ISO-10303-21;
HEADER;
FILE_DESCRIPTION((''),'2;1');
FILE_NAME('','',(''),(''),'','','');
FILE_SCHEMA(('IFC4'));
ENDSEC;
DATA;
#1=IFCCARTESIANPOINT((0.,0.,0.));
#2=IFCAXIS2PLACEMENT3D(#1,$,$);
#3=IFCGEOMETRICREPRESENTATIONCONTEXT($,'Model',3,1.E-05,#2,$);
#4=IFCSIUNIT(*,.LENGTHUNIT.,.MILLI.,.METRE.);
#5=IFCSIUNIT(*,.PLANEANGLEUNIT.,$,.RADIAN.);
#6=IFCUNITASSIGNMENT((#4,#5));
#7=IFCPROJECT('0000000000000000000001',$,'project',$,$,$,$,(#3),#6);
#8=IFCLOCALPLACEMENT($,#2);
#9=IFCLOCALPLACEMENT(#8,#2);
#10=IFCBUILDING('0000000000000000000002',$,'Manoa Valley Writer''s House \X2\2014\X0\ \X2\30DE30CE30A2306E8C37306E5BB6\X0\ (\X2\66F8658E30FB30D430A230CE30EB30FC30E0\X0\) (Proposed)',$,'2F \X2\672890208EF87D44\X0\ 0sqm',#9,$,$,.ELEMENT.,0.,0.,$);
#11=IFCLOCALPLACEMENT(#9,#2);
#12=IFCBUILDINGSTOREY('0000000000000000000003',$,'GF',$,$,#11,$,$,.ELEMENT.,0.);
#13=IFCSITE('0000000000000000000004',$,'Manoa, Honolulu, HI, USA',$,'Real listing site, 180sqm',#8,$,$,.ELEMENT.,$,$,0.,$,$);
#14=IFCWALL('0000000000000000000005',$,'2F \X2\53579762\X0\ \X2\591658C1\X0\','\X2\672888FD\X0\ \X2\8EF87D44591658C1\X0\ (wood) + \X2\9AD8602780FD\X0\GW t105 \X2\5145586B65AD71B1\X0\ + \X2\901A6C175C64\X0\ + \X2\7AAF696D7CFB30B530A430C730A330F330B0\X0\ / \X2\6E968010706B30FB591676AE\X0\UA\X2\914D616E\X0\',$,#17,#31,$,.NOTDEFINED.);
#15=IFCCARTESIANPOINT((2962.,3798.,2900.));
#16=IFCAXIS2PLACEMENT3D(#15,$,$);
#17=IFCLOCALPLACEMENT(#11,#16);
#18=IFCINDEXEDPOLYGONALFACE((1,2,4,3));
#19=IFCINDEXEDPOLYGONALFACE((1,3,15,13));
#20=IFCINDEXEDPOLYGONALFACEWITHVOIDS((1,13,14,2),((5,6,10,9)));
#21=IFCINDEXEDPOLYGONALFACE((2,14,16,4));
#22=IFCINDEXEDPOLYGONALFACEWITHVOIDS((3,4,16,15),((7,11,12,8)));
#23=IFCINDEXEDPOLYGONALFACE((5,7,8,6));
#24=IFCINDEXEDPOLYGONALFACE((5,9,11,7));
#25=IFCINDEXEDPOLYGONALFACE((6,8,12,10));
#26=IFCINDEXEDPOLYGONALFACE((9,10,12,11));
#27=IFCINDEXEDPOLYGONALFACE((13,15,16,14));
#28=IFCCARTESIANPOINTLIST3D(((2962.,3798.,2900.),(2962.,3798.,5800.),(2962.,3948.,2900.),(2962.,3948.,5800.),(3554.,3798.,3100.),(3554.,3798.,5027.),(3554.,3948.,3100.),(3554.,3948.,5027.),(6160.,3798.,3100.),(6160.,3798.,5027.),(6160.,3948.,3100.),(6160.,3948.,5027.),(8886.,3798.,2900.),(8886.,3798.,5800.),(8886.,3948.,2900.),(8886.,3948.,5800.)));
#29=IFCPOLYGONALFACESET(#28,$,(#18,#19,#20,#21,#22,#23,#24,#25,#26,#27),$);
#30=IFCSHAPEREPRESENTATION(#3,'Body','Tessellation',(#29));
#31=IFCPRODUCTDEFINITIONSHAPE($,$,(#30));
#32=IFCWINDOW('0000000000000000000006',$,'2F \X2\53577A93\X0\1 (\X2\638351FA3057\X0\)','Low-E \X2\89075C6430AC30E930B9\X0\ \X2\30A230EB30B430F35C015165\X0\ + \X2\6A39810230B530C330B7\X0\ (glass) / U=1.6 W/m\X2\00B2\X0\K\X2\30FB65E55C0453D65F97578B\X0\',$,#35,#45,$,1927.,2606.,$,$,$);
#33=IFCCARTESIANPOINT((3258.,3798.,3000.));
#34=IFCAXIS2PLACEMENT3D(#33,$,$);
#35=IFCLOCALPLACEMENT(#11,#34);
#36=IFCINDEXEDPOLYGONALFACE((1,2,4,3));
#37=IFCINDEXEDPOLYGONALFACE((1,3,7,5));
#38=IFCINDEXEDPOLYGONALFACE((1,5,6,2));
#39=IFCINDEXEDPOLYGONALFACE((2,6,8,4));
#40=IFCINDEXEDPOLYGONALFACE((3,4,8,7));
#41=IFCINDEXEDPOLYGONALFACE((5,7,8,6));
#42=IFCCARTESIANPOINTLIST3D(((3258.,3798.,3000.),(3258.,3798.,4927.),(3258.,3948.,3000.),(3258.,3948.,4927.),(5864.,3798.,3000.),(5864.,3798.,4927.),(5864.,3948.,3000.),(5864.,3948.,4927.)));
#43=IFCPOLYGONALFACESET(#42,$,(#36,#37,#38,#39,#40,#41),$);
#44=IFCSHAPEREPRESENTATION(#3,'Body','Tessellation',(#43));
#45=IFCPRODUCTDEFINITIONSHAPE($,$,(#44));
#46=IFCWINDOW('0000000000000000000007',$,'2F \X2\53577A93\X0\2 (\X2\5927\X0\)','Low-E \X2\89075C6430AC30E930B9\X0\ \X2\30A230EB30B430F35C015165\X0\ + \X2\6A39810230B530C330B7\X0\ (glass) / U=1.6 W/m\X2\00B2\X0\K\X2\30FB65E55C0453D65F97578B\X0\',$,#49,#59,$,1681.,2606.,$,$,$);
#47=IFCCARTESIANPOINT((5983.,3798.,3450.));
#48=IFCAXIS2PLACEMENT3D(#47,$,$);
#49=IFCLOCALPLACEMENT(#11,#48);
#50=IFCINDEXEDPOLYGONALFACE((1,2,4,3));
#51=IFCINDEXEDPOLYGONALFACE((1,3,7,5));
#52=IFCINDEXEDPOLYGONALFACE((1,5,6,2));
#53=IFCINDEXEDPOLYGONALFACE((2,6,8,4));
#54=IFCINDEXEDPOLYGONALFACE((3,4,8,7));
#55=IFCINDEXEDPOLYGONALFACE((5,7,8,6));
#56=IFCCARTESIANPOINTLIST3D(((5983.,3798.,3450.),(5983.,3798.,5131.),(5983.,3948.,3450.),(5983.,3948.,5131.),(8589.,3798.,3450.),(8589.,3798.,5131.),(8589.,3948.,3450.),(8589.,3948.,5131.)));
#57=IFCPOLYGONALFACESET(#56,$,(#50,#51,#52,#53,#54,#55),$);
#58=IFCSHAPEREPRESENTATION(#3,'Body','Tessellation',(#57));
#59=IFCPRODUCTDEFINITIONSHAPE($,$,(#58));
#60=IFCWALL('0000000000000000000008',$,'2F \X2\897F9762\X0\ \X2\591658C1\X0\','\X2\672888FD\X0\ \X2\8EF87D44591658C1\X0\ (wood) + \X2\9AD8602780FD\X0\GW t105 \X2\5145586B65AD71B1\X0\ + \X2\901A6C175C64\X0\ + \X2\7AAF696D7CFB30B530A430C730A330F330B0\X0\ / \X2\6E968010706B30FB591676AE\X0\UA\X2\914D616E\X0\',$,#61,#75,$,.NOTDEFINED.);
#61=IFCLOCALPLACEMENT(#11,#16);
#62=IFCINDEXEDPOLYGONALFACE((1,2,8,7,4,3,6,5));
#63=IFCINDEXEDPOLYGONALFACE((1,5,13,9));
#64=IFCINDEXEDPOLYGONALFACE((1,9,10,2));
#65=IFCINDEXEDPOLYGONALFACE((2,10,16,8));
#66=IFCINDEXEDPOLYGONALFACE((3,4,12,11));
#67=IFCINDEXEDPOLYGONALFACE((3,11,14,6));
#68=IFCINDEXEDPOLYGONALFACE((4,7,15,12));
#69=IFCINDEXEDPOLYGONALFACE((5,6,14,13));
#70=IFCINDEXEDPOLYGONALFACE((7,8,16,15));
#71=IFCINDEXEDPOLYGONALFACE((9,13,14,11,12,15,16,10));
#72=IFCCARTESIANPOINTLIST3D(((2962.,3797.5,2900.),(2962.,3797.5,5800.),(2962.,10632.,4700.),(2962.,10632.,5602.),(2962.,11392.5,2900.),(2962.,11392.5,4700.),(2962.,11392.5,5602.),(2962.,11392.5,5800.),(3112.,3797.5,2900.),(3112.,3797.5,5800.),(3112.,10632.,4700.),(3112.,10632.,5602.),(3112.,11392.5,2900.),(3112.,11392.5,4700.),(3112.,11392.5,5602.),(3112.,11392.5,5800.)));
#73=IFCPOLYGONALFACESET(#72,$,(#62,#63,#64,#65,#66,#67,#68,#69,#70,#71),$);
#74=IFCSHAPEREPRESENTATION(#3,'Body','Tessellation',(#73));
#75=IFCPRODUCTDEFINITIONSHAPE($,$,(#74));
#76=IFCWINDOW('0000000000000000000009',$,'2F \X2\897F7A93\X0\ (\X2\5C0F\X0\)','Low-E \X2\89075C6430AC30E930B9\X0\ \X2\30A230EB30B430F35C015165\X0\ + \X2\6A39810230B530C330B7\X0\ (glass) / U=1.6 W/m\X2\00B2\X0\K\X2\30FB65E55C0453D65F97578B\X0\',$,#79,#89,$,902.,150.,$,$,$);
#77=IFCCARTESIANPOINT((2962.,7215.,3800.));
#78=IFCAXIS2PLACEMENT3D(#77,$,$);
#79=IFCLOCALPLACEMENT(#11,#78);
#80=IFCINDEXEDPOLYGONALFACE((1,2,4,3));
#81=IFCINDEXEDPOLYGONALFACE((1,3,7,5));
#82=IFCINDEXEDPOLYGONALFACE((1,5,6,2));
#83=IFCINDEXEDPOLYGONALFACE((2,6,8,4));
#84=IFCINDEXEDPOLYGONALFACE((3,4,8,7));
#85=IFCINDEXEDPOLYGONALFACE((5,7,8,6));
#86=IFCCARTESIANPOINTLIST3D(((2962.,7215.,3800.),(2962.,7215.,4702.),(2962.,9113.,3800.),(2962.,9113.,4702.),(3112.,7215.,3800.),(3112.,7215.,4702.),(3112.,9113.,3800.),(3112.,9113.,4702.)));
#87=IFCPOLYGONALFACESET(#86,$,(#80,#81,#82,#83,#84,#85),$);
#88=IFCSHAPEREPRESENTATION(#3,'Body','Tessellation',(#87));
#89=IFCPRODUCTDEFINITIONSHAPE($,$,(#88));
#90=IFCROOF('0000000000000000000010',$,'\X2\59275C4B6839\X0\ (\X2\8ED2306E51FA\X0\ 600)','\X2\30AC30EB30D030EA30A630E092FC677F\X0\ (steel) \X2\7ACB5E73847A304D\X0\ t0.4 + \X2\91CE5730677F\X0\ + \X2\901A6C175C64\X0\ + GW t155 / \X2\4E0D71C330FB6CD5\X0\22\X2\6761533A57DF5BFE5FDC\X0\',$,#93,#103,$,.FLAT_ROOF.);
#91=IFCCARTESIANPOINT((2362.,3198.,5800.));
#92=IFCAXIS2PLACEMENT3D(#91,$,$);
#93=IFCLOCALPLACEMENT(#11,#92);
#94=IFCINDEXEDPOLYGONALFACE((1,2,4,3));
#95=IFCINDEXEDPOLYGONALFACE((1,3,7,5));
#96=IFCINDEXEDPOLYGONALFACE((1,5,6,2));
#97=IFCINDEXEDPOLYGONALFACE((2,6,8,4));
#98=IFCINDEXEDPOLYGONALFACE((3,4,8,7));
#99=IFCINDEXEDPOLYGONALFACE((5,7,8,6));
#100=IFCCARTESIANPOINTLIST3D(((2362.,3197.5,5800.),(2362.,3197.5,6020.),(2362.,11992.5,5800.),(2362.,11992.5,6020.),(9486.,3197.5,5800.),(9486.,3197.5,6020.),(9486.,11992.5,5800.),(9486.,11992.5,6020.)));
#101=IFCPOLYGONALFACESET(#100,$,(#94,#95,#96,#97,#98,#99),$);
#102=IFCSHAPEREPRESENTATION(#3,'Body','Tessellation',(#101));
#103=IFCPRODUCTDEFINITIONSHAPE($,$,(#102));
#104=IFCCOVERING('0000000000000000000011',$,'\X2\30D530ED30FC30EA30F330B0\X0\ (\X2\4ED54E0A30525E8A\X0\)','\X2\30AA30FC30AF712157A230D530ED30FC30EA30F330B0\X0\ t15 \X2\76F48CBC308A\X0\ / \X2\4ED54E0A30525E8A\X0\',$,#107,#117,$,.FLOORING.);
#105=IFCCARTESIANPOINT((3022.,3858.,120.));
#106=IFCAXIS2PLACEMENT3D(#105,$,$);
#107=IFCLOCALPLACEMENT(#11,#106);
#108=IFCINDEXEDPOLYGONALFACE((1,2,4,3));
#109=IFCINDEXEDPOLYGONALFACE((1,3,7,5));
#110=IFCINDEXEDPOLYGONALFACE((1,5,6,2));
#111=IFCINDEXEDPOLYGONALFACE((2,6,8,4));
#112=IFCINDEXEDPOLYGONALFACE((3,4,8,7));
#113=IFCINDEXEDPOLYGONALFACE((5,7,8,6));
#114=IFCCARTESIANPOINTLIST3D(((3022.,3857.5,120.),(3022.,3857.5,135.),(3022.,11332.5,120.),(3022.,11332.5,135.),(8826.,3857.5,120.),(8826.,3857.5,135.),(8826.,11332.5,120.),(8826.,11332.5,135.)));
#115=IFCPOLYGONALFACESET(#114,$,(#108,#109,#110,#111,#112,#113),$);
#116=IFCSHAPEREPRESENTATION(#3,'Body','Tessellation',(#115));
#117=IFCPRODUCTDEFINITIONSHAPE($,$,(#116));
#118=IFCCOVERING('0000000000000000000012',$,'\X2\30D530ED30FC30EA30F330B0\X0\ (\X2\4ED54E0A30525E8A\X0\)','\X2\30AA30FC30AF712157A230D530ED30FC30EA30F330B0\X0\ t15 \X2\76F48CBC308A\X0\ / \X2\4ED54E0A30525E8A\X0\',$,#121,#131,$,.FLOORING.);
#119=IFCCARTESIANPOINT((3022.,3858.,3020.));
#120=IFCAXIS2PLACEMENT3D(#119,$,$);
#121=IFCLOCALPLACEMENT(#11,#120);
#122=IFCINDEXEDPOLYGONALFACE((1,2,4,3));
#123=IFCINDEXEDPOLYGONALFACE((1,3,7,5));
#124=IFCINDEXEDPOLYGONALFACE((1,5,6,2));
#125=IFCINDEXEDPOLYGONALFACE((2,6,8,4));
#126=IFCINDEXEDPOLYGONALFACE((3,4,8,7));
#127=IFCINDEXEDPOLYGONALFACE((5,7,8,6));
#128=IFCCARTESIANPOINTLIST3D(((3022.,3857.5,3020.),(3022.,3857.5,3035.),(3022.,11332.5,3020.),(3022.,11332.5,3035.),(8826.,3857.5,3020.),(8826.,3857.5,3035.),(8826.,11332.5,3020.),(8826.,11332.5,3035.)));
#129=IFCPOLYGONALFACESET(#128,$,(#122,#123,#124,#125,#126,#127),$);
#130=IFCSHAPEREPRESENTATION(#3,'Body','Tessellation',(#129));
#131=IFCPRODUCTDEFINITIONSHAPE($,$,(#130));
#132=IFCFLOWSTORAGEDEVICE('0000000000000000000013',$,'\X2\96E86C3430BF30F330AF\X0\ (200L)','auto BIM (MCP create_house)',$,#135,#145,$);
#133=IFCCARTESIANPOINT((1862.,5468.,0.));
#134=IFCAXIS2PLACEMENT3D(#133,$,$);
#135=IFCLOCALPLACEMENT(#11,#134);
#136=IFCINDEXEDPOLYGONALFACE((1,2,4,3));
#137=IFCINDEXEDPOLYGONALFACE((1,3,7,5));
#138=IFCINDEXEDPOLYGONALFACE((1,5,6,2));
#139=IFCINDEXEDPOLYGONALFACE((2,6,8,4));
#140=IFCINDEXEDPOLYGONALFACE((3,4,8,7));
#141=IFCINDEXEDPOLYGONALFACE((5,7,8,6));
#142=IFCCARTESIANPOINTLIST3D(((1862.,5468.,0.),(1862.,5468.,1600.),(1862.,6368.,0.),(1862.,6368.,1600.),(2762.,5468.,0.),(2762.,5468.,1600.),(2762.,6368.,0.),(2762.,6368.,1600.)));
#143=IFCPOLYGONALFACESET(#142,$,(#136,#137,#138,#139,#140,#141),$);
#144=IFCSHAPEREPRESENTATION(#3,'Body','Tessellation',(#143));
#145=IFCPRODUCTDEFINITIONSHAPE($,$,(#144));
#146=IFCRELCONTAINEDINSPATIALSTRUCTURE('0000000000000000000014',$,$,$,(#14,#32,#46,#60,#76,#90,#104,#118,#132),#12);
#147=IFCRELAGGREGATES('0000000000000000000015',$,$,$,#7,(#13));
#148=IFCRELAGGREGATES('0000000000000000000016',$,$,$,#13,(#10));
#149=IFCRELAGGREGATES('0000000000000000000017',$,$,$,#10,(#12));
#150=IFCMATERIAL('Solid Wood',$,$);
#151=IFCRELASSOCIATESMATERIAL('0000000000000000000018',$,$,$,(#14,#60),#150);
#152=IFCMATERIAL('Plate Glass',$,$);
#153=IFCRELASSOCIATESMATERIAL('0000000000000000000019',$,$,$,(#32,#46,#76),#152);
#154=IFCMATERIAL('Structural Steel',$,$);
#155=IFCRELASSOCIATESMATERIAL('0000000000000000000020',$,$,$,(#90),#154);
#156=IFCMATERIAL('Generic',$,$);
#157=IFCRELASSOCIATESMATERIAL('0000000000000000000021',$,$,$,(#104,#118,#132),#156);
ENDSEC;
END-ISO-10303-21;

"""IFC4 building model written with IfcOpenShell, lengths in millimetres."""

from ifc_helpers import new_model, si_unit, frame, frame_2d, origin, place, context, project, spatial, rectangle, extrude, material, element, fill, save


model = new_model("IFC4")

# Units and contexts
model_context = context("Model", 3, precision=1e-05, world=origin())
ifc_project = project(units=[si_unit("LENGTHUNIT", "METRE", prefix="MILLI"), si_unit("PLANEANGLEUNIT", "RADIAN")], contexts=[model_context])

# Site, building, storey
site_placement = place(None, origin())
site = spatial("IfcSite", under=ifc_project, at=site_placement, Name="Manoa, Honolulu, HI, USA", ObjectType="Real listing site, 180sqm", CompositionType="ELEMENT", RefElevation=0.0)
building_placement = place(site_placement, origin())
building = spatial("IfcBuilding", under=site, at=building_placement, Name="Manoa Valley Writer's House — マノアの谷の家 (書斎・ピアノルーム) (Proposed)", ObjectType="2F 木造軸組 0sqm", CompositionType="ELEMENT", ElevationOfRefHeight=0.0, ElevationOfTerrain=0.0)
storey_placement = place(building_placement, origin())
storey = spatial("IfcBuildingStorey", under=building, at=storey_placement, Name="GF", CompositionType="ELEMENT", Elevation=0.0)

# Shared definitions
ifc_material_1 = material(Name="Solid Wood")

# Shared definitions
ifc_material_2 = material(Name="Plate Glass")

# Wall, openings, windows
wall_1_placement = place(storey_placement, frame((2962.0, 3798.0, 2900.0)))
wall_1 = element("IfcWall", 1, at=wall_1_placement, inside=storey, material=ifc_material_1, Name="2F 南面 外壁", Description="木製 軸組外壁 (wood) + 高性能GW t105 充填断熱 + 通気層 + 窯業系サイディング / 準耐火・外皮UA配慮", PredefinedType="NOTDEFINED", context=model_context, shape_type="SweptSolid", body=[
    extrude(rectangle(XDim=5924.0, YDim=150.0, at=frame_2d((2962.0, 75.0))), frame((2962.0, 3798.0, 2900.0)), (0.0, 0.0, 1.0), 2900.0),
])
opening_1_placement = place(storey_placement, frame((3258.0, 3798.0, 3000.0)))
opening_1 = element("IfcOpeningElement", 2, at=opening_1_placement, cuts=wall_1, PredefinedType="NOTDEFINED", context=model_context, shape_type="SweptSolid", body=[
    extrude(rectangle(XDim=2606.0, YDim=150.0, at=frame_2d((1303.0, 75.0))), frame((3258.0, 3798.0, 3000.0)), (0.0, 0.0, 1.0), 1927.0),
])
opening_2_placement = place(storey_placement, frame((5983.0, 3798.0, 3450.0)))
opening_2 = element("IfcOpeningElement", 3, at=opening_2_placement, cuts=wall_1, PredefinedType="NOTDEFINED", context=model_context, shape_type="SweptSolid", body=[
    extrude(rectangle(XDim=2606.0, YDim=150.0, at=frame_2d((1303.0, 75.0))), frame((5983.0, 3798.0, 3450.0)), (0.0, 0.0, 1.0), 1681.0),
])
window_1_placement = place(storey_placement, frame((3258.0, 3798.0, 3000.0)))
window_1 = element("IfcWindow", 4, at=window_1_placement, inside=storey, material=ifc_material_2, Name="2F 南窓1 (掃出し)", Description="Low-E 複層ガラス アルゴン封入 + 樹脂サッシ (glass) / U=1.6 W/m²K・日射取得型", OverallHeight=1927.0, OverallWidth=2606.0, context=model_context, shape_type="SweptSolid", body=[
    extrude(rectangle(XDim=2606.0, YDim=150.0, at=frame_2d((1303.0, 75.0))), frame((3258.0, 3798.0, 3000.0)), (0.0, 0.0, 1.0), 1927.0),
])
fill(opening_1, window_1)
window_2_placement = place(storey_placement, frame((5983.0, 3798.0, 3450.0)))
window_2 = element("IfcWindow", 5, at=window_2_placement, inside=storey, material=ifc_material_2, Name="2F 南窓2 (大)", Description="Low-E 複層ガラス アルゴン封入 + 樹脂サッシ (glass) / U=1.6 W/m²K・日射取得型", OverallHeight=1681.0, OverallWidth=2606.0, context=model_context, shape_type="SweptSolid", body=[
    extrude(rectangle(XDim=2606.0, YDim=150.0, at=frame_2d((1303.0, 75.0))), frame((5983.0, 3798.0, 3450.0)), (0.0, 0.0, 1.0), 1681.0),
])
fill(opening_2, window_2)

# Wall, opening, window
wall_2_placement = place(storey_placement, frame((2962.0, 3798.0, 2900.0)))
wall_2 = element("IfcWall", 6, at=wall_2_placement, inside=storey, material=ifc_material_1, Name="2F 西面 外壁", Description="木製 軸組外壁 (wood) + 高性能GW t105 充填断熱 + 通気層 + 窯業系サイディング / 準耐火・外皮UA配慮", PredefinedType="NOTDEFINED", context=model_context, shape_type="SweptSolid", body=[
    extrude(rectangle(XDim=150.0, YDim=7595.0, at=frame_2d((75.0, 3797.0))), frame((2962.0, 3798.0, 2900.0)), (0.0, 0.0, 1.0), 2900.0),
])
opening_3_placement = place(storey_placement, frame((2962.0, 7215.0, 3800.0)))
opening_3 = element("IfcOpeningElement", 7, at=opening_3_placement, cuts=wall_2, PredefinedType="NOTDEFINED", context=model_context, shape_type="SweptSolid", body=[
    extrude(rectangle(XDim=150.0, YDim=1898.0, at=frame_2d((75.0, 949.0))), frame((2962.0, 7215.0, 3800.0)), (0.0, 0.0, 1.0), 902.0),
])
window_3_placement = place(storey_placement, frame((2962.0, 7215.0, 3800.0)))
window_3 = element("IfcWindow", 8, at=window_3_placement, inside=storey, material=ifc_material_2, Name="2F 西窓 (小)", Description="Low-E 複層ガラス アルゴン封入 + 樹脂サッシ (glass) / U=1.6 W/m²K・日射取得型", OverallHeight=902.0, OverallWidth=150.0, context=model_context, shape_type="SweptSolid", body=[
    extrude(rectangle(XDim=150.0, YDim=1898.0, at=frame_2d((75.0, 949.0))), frame((2962.0, 7215.0, 3800.0)), (0.0, 0.0, 1.0), 902.0),
])
fill(opening_3, window_3)

# Roof
ifc_material_3 = material(Name="Structural Steel")
roof_placement = place(storey_placement, frame((2362.0, 3198.0, 5800.0)))
element("IfcRoof", 9, at=roof_placement, inside=storey, material=ifc_material_3, Name="大屋根 (軒の出 600)", Description="ガルバリウム鋼板 (steel) 立平葺き t0.4 + 野地板 + 通気層 + GW t155 / 不燃・法22条区域対応", PredefinedType="FLAT_ROOF", context=model_context, shape_type="SweptSolid", body=[
    extrude(rectangle(XDim=7124.0, YDim=8795.0, at=frame_2d((3562.0, 4397.0))), frame((2362.0, 3198.0, 5800.0)), (0.0, 0.0, 1.0), 220.0),
])

# Coverings
ifc_material_4 = material(Name="Generic")
covering_1_placement = place(storey_placement, frame((3022.0, 3858.0, 120.0)))
element("IfcCovering", 10, at=covering_1_placement, inside=storey, material=ifc_material_4, Name="フローリング (仕上げ床)", Description="オーク無垢フローリング t15 直貼り / 仕上げ床", PredefinedType="FLOORING", context=model_context, shape_type="SweptSolid", body=[
    extrude(rectangle(XDim=5804.0, YDim=7475.0, at=frame_2d((2902.0, 3737.0))), frame((3022.0, 3858.0, 120.0)), (0.0, 0.0, 1.0), 15.0),
])
covering_2_placement = place(storey_placement, frame((3022.0, 3858.0, 3020.0)))
element("IfcCovering", 11, at=covering_2_placement, inside=storey, material=ifc_material_4, Name="フローリング (仕上げ床)", Description="オーク無垢フローリング t15 直貼り / 仕上げ床", PredefinedType="FLOORING", context=model_context, shape_type="SweptSolid", body=[
    extrude(rectangle(XDim=5804.0, YDim=7475.0, at=frame_2d((2902.0, 3737.0))), frame((3022.0, 3858.0, 3020.0)), (0.0, 0.0, 1.0), 15.0),
])

# Flow storage device
flow_storage_device_placement = place(storey_placement, frame((1862.0, 5468.0, 0.0)))
element("IfcFlowStorageDevice", 12, at=flow_storage_device_placement, inside=storey, material=ifc_material_4, Name="雨水タンク (200L)", Description="auto BIM (MCP create_house)", context=model_context, shape_type="SweptSolid", body=[
    extrude(rectangle(XDim=900.0, YDim=900.0, at=frame_2d((450.0, 450.0))), frame((1862.0, 5468.0, 0.0)), (0.0, 0.0, 1.0), 1600.0),
])

save(model, "model.ifc")
